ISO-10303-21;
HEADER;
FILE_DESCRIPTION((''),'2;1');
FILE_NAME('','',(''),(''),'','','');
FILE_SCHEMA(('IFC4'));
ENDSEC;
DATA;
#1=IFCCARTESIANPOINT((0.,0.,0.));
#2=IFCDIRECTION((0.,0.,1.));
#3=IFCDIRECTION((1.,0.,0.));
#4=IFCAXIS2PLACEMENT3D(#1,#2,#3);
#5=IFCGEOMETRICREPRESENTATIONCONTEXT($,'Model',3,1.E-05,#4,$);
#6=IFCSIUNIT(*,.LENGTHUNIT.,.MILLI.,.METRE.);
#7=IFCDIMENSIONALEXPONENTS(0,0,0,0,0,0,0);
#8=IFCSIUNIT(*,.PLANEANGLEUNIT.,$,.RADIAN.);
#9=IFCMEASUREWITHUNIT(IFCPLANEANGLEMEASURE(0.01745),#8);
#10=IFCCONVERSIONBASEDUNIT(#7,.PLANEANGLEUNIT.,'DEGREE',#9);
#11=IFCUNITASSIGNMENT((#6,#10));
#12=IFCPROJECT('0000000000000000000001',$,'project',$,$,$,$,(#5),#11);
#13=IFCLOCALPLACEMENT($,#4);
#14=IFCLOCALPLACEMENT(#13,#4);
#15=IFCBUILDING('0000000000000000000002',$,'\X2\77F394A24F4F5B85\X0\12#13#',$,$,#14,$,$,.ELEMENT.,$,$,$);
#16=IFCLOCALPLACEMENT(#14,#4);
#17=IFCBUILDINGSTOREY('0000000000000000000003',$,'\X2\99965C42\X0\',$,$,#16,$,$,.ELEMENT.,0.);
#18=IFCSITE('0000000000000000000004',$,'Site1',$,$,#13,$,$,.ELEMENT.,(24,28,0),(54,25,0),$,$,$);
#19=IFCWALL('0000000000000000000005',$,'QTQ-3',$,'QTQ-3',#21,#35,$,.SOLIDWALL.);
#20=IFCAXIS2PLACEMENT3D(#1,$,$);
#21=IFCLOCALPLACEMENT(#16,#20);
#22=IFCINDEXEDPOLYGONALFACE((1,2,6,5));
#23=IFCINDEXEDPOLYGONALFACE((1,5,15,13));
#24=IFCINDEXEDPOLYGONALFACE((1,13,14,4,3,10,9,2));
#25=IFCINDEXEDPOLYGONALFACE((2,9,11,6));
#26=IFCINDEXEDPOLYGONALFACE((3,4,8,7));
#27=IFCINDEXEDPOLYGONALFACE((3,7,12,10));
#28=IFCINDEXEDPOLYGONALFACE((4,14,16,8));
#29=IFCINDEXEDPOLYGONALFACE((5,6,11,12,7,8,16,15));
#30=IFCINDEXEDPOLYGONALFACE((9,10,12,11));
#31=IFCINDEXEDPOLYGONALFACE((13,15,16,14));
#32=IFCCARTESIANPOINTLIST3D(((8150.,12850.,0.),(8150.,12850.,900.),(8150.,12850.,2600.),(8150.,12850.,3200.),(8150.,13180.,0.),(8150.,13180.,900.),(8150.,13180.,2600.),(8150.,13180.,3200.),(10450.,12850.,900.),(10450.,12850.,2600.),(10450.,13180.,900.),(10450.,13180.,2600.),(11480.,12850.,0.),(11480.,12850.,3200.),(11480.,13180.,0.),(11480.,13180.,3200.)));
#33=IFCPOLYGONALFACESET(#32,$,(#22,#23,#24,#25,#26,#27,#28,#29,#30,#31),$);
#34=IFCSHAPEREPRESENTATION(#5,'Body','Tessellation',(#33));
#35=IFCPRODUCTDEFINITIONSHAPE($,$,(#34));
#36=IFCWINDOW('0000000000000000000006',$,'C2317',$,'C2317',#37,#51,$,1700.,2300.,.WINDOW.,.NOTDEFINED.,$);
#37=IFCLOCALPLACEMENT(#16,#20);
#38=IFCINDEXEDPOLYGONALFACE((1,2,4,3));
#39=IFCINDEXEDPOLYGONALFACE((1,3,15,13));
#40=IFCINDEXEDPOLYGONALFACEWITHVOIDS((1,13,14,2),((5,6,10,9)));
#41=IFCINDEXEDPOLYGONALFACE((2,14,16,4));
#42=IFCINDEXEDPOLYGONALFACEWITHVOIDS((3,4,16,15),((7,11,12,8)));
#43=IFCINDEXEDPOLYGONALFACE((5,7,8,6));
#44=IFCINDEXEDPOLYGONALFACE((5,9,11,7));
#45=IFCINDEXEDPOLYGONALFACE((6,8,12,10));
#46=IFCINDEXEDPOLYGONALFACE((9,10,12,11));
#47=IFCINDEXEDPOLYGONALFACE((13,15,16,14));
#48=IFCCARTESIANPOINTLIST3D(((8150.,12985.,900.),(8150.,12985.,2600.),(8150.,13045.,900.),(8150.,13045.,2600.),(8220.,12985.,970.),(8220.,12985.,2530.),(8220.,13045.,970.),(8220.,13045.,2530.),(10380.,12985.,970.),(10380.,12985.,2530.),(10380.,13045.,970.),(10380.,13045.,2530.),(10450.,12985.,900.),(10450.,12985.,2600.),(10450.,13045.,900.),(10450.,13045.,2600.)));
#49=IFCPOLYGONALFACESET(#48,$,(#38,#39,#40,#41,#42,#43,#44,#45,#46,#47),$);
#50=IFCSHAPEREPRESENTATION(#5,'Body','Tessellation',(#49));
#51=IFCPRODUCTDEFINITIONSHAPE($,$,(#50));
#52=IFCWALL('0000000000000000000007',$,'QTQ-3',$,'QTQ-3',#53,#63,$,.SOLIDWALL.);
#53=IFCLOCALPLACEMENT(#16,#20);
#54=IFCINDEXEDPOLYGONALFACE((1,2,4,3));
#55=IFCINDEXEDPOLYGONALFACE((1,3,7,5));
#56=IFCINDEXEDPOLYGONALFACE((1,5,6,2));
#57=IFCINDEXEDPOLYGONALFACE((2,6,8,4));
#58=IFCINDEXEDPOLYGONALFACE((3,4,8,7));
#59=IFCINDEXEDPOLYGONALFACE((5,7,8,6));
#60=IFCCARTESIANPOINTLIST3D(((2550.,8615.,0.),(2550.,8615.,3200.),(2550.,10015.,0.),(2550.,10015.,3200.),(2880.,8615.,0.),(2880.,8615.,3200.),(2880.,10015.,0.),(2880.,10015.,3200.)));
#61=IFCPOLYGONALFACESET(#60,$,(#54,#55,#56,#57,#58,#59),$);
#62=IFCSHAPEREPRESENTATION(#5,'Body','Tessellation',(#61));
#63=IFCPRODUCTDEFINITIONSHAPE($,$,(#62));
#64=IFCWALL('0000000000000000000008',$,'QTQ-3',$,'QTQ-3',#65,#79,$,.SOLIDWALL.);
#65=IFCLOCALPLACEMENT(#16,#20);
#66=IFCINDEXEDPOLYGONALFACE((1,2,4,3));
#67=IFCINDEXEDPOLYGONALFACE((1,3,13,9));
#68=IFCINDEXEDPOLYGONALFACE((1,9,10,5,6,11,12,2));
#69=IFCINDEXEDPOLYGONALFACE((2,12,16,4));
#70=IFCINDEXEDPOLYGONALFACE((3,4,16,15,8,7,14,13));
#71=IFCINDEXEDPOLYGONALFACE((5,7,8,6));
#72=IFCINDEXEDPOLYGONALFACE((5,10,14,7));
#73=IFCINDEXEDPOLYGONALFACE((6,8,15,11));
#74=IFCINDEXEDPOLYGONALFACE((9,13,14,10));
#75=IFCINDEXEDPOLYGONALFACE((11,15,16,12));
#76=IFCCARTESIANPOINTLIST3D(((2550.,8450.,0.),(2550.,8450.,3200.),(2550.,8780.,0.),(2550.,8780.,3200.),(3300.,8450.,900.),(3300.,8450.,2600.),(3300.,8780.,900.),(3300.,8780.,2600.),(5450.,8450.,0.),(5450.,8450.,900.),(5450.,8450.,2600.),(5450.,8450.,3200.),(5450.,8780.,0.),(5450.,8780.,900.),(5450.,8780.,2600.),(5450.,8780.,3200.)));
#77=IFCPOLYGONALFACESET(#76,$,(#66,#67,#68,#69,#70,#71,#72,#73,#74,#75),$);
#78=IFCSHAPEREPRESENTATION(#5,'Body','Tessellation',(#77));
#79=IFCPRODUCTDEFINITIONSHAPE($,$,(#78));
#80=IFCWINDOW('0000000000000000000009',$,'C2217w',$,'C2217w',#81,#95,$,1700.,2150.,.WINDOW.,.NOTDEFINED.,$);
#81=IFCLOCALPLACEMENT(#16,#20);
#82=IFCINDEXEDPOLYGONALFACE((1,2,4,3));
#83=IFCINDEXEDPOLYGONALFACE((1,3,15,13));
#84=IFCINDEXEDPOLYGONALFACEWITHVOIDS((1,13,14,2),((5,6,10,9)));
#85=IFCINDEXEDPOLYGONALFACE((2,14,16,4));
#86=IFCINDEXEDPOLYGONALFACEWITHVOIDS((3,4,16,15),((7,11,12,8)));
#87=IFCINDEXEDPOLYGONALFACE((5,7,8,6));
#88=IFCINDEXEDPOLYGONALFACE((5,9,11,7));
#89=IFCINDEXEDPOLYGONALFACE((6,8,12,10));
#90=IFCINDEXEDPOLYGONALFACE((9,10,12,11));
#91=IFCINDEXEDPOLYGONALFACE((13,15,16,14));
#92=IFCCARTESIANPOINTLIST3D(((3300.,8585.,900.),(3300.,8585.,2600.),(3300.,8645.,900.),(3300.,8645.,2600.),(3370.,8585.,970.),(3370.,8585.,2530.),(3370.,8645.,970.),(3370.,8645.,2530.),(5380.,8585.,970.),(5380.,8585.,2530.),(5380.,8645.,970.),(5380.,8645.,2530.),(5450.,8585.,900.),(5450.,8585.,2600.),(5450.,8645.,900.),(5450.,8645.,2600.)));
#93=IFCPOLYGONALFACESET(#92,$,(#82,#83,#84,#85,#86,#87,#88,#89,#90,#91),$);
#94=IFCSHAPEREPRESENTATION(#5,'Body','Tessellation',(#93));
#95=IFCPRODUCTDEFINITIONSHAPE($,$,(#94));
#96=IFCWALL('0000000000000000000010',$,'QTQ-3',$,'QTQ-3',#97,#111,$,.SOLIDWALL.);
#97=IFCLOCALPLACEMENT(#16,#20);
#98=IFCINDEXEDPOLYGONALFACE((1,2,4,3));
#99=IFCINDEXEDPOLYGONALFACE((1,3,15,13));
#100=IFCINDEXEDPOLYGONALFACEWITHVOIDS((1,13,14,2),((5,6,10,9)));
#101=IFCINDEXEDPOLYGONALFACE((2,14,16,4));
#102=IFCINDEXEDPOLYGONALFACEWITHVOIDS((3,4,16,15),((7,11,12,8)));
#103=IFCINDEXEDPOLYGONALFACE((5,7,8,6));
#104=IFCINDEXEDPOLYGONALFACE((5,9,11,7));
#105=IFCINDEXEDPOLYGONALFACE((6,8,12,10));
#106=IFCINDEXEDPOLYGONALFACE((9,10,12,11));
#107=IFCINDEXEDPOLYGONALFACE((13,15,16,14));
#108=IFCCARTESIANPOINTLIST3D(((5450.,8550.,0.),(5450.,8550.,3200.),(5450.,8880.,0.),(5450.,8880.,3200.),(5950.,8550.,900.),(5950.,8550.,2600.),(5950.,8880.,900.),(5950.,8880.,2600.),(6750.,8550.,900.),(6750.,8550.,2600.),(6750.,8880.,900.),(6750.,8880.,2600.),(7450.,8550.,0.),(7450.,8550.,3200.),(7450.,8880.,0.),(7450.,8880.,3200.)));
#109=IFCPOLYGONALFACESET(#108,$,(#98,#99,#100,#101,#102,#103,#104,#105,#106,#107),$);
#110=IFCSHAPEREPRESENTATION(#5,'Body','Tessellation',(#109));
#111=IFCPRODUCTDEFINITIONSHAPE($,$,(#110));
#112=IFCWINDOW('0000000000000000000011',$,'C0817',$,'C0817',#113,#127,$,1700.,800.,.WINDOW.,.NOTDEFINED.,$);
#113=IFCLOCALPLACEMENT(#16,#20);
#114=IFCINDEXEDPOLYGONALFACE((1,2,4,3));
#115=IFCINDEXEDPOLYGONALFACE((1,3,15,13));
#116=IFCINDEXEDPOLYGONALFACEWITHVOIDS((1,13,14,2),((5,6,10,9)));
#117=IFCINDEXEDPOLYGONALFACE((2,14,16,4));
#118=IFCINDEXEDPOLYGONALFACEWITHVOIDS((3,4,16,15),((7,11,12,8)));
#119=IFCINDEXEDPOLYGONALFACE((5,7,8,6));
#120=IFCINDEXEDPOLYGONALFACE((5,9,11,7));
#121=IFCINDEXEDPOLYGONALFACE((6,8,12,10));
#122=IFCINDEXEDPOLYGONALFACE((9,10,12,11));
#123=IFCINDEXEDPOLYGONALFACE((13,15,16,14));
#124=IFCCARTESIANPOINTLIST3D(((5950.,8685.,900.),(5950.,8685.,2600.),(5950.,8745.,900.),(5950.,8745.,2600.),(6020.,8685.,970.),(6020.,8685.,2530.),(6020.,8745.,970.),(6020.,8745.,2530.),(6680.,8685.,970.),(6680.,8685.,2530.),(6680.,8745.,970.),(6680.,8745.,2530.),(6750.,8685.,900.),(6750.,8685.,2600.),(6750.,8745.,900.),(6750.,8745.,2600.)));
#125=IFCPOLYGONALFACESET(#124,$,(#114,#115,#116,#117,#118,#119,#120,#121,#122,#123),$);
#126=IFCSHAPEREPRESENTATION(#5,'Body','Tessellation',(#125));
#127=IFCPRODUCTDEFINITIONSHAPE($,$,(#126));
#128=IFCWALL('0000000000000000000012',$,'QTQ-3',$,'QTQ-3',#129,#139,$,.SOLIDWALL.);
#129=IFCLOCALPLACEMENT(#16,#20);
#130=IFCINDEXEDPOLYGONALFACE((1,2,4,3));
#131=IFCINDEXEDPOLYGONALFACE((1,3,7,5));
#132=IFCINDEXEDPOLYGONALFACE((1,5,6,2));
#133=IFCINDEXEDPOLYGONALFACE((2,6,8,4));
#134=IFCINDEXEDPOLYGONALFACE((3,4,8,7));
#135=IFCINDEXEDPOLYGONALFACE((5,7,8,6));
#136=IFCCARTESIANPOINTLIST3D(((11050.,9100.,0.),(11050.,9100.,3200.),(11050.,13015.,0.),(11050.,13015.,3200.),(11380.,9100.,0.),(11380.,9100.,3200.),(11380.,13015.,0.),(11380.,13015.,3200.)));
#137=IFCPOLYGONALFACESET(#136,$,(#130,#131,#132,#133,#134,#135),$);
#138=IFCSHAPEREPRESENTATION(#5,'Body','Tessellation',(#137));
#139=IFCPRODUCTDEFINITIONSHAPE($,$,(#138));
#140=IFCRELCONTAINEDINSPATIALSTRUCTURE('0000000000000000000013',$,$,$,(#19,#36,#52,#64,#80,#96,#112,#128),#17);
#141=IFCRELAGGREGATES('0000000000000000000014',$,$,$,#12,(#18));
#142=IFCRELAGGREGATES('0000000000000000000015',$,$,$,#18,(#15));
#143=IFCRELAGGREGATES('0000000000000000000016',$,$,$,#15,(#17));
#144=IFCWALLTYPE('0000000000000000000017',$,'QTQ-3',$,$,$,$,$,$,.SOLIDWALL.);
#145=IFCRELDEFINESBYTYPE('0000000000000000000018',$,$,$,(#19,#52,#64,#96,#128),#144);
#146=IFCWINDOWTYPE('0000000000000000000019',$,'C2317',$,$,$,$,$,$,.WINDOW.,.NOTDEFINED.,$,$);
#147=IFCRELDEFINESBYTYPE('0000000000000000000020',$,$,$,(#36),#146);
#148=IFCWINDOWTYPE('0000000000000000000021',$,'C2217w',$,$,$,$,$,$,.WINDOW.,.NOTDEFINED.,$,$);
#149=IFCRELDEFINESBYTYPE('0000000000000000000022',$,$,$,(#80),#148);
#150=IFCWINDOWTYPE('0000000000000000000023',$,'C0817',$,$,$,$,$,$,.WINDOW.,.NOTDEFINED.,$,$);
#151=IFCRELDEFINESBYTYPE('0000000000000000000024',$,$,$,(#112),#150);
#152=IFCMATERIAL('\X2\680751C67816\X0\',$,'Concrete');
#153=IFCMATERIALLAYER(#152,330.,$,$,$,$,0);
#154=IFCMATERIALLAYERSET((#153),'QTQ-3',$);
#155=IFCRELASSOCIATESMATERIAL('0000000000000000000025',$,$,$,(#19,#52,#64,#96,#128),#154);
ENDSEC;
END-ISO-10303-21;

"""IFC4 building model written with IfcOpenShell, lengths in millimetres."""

from ifc_helpers import new_model, entity, si_unit, converted_unit, frame, origin_with_axes, place, context, project, spatial, polyline, outline, extrude, material, layer, layer_set, type_object, element, fill, save


model = new_model("IFC4")

# Units and contexts
model_context = context("Model", 3, precision=1e-05, world=origin_with_axes())
ifc_project = project(units=[si_unit("LENGTHUNIT", "METRE", prefix="MILLI"), converted_unit("PLANEANGLEUNIT", "DEGREE", entity("IfcPlaneAngleMeasure", 0.01745), si_unit("PLANEANGLEUNIT", "RADIAN"), dimensions=[0, 0, 0, 0, 0, 0, 0])], contexts=[model_context])

# Site, building, storey
site_placement = place(None, origin_with_axes())
site = spatial("IfcSite", under=ifc_project, at=site_placement, Name="Site1", CompositionType="ELEMENT", RefLatitude=(24, 28, 0), RefLongitude=(54, 25, 0))
building_placement = place(site_placement, origin_with_axes())
building = spatial("IfcBuilding", under=site, at=building_placement, Name="石钢住宅12#13#", CompositionType="ELEMENT")
storey_placement = place(building_placement, origin_with_axes())
storey = spatial("IfcBuildingStorey", under=building, at=storey_placement, Name="首层", CompositionType="ELEMENT", Elevation=0.0)

# Wall, opening, window
ifc_material = material(Name="标准砖", Category="Concrete")
ifc_layer = layer(ifc_material, 330.0, Priority=0)
ifc_layer_set = layer_set([ifc_layer], Name="QTQ-3")
wall_type = type_object("IfcWallType", Name="QTQ-3", PredefinedType="SOLIDWALL")
wall_1_placement = place(storey_placement, origin_with_axes())
wall_1 = element("IfcWall", 1, at=wall_1_placement, inside=storey, type_object=wall_type, material=ifc_layer_set, Name="QTQ-3", ObjectType="QTQ-3", PredefinedType="SOLIDWALL", context=model_context, shape_type="SweptSolid", body=[
    extrude(outline(polyline([(0.0, 0.0), (3200.0, 0.0), (3200.0, 3330.0), (0.0, 3330.0), (0.0, 0.0)])), frame((8150.0, 13180.0, 3200.0), z_axis=(0.0, -1.0, 0.0), x_axis=(0.0, 0.0, -1.0)), (0.0, 0.0, 1.0), 330.0),
])
opening_1_placement = place(storey_placement, origin_with_axes())
opening_1 = element("IfcOpeningElement", 2, at=opening_1_placement, cuts=wall_1, PredefinedType="OPENING", context=model_context, shape_type="SweptSolid", body=[
    extrude(outline(polyline([(0.0, 0.0), (2300.0, 0.0), (2300.0, 1700.0), (0.0, 1700.0), (0.0, 0.0)])), frame((8150.0, 14180.0, 900.0), z_axis=(0.0, -1.0, 0.0), x_axis=(1.0, 0.0, 0.0)), (0.0, 0.0, 1.0), 2330.0),
])
window_type_1 = type_object("IfcWindowType", Name="C2317", PartitioningType="NOTDEFINED", PredefinedType="WINDOW")
window_1_placement = place(storey_placement, origin_with_axes())
window_1 = element("IfcWindow", 3, at=window_1_placement, inside=storey, type_object=window_type_1, Name="C2317", ObjectType="C2317", OverallHeight=1700.0, OverallWidth=2300.0, PartitioningType="NOTDEFINED", PredefinedType="WINDOW", context=model_context, shape_type="SweptSolid", body=[
    extrude(outline(polyline([(-1150.0, -850.0), (1150.0, -850.0), (1150.0, 850.0), (-1150.0, 850.0), (-1150.0, -850.0)]), holes=[polyline([(-1080.0, -780.0), (-1080.0, 780.0), (1080.0, 780.0), (1080.0, -780.0), (-1080.0, -780.0)])]), frame((9300.0, 13045.0, 1750.0), z_axis=(0.0, -1.0, 0.0), x_axis=(1.0, 0.0, 0.0)), (0.0, 0.0, 1.0), 60.0),
])
fill(opening_1, window_1)

# Wall
wall_2_placement = place(storey_placement, origin_with_axes())
element("IfcWall", 4, at=wall_2_placement, inside=storey, type_object=wall_type, material=ifc_layer_set, Name="QTQ-3", ObjectType="QTQ-3", PredefinedType="SOLIDWALL", context=model_context, shape_type="SweptSolid", body=[
    extrude(outline(polyline([(0.0, 0.0), (3200.0, 0.0), (3200.0, 1400.0), (0.0, 1400.0), (0.0, 0.0)])), frame((2880.0, 10015.0, 3200.0), z_axis=(-1.0, 0.0, 0.0), x_axis=(0.0, 0.0, -1.0)), (0.0, 0.0, 1.0), 330.0),
])

# Walls, openings, windows
wall_3_placement = place(storey_placement, origin_with_axes())
wall_3 = element("IfcWall", 5, at=wall_3_placement, inside=storey, type_object=wall_type, material=ifc_layer_set, Name="QTQ-3", ObjectType="QTQ-3", PredefinedType="SOLIDWALL", context=model_context, shape_type="SweptSolid", body=[
    extrude(outline(polyline([(0.0, 0.0), (3200.0, 0.0), (3200.0, 2900.0), (0.0, 2900.0), (0.0, 0.0)])), frame((2550.0, 8780.0, 3200.0), z_axis=(0.0, -1.0, 0.0), x_axis=(0.0, 0.0, -1.0)), (0.0, 0.0, 1.0), 330.0),
])
opening_2_placement = place(storey_placement, origin_with_axes())
opening_2 = element("IfcOpeningElement", 6, at=opening_2_placement, cuts=wall_3, PredefinedType="OPENING", context=model_context, shape_type="SweptSolid", body=[
    extrude(outline(polyline([(0.0, 0.0), (2150.0, 0.0), (2150.0, 1700.0), (0.0, 1700.0), (0.0, 0.0)])), frame((3300.0, 9780.0, 900.0), z_axis=(0.0, -1.0, 0.0), x_axis=(1.0, 0.0, 0.0)), (0.0, 0.0, 1.0), 2330.0),
])
window_type_2 = type_object("IfcWindowType", Name="C2217w", PartitioningType="NOTDEFINED", PredefinedType="WINDOW")
window_2_placement = place(storey_placement, origin_with_axes())
window_2 = element("IfcWindow", 7, at=window_2_placement, inside=storey, type_object=window_type_2, Name="C2217w", ObjectType="C2217w", OverallHeight=1700.0, OverallWidth=2150.0, PartitioningType="NOTDEFINED", PredefinedType="WINDOW", context=model_context, shape_type="SweptSolid", body=[
    extrude(outline(polyline([(-1075.0, -850.0), (1075.0, -850.0), (1075.0, 850.0), (-1075.0, 850.0), (-1075.0, -850.0)]), holes=[polyline([(-1005.0, -780.0), (-1005.0, 780.0), (1005.0, 780.0), (1005.0, -780.0), (-1005.0, -780.0)])]), frame((4375.0, 8645.0, 1750.0), z_axis=(0.0, -1.0, 0.0), x_axis=(1.0, 0.0, 0.0)), (0.0, 0.0, 1.0), 60.0),
])
fill(opening_2, window_2)
wall_4_placement = place(storey_placement, origin_with_axes())
wall_4 = element("IfcWall", 8, at=wall_4_placement, inside=storey, type_object=wall_type, material=ifc_layer_set, Name="QTQ-3", ObjectType="QTQ-3", PredefinedType="SOLIDWALL", context=model_context, shape_type="SweptSolid", body=[
    extrude(outline(polyline([(0.0, 0.0), (3200.0, 0.0), (3200.0, 2000.0), (0.0, 2000.0), (0.0, 0.0)])), frame((5450.0, 8880.0, 3200.0), z_axis=(0.0, -1.0, 0.0), x_axis=(0.0, 0.0, -1.0)), (0.0, 0.0, 1.0), 330.0),
])
opening_3_placement = place(storey_placement, origin_with_axes())
opening_3 = element("IfcOpeningElement", 9, at=opening_3_placement, cuts=wall_4, PredefinedType="OPENING", context=model_context, shape_type="SweptSolid", body=[
    extrude(outline(polyline([(0.0, 0.0), (800.0, 0.0), (800.0, 1700.0), (0.0, 1700.0), (0.0, 0.0)])), frame((5950.0, 9880.0, 900.0), z_axis=(0.0, -1.0, 0.0), x_axis=(1.0, 0.0, 0.0)), (0.0, 0.0, 1.0), 2330.0),
])
window_type_3 = type_object("IfcWindowType", Name="C0817", PartitioningType="NOTDEFINED", PredefinedType="WINDOW")
window_3_placement = place(storey_placement, origin_with_axes())
window_3 = element("IfcWindow", 10, at=window_3_placement, inside=storey, type_object=window_type_3, Name="C0817", ObjectType="C0817", OverallHeight=1700.0, OverallWidth=800.0, PartitioningType="NOTDEFINED", PredefinedType="WINDOW", context=model_context, shape_type="SweptSolid", body=[
    extrude(outline(polyline([(-400.0, -850.0), (400.0, -850.0), (400.0, 850.0), (-400.0, 850.0), (-400.0, -850.0)]), holes=[polyline([(-330.0, -780.0), (-330.0, 780.0), (330.0, 780.0), (330.0, -780.0), (-330.0, -780.0)])]), frame((6350.0, 8745.0, 1750.0), z_axis=(0.0, -1.0, 0.0), x_axis=(1.0, 0.0, 0.0)), (0.0, 0.0, 1.0), 60.0),
])
fill(opening_3, window_3)

# Wall
wall_5_placement = place(storey_placement, origin_with_axes())
element("IfcWall", 11, at=wall_5_placement, inside=storey, type_object=wall_type, material=ifc_layer_set, Name="QTQ-3", ObjectType="QTQ-3", PredefinedType="SOLIDWALL", context=model_context, shape_type="SweptSolid", body=[
    extrude(outline(polyline([(0.0, 0.0), (3200.0, 0.0), (3200.0, 3915.0), (0.0, 3915.0), (0.0, 0.0)])), frame((11050.0, 9100.0, 3200.0), z_axis=(1.0, 0.0, 0.0), x_axis=(0.0, 0.0, -1.0)), (0.0, 0.0, 1.0), 330.0),
])

save(model, "model.ifc")
